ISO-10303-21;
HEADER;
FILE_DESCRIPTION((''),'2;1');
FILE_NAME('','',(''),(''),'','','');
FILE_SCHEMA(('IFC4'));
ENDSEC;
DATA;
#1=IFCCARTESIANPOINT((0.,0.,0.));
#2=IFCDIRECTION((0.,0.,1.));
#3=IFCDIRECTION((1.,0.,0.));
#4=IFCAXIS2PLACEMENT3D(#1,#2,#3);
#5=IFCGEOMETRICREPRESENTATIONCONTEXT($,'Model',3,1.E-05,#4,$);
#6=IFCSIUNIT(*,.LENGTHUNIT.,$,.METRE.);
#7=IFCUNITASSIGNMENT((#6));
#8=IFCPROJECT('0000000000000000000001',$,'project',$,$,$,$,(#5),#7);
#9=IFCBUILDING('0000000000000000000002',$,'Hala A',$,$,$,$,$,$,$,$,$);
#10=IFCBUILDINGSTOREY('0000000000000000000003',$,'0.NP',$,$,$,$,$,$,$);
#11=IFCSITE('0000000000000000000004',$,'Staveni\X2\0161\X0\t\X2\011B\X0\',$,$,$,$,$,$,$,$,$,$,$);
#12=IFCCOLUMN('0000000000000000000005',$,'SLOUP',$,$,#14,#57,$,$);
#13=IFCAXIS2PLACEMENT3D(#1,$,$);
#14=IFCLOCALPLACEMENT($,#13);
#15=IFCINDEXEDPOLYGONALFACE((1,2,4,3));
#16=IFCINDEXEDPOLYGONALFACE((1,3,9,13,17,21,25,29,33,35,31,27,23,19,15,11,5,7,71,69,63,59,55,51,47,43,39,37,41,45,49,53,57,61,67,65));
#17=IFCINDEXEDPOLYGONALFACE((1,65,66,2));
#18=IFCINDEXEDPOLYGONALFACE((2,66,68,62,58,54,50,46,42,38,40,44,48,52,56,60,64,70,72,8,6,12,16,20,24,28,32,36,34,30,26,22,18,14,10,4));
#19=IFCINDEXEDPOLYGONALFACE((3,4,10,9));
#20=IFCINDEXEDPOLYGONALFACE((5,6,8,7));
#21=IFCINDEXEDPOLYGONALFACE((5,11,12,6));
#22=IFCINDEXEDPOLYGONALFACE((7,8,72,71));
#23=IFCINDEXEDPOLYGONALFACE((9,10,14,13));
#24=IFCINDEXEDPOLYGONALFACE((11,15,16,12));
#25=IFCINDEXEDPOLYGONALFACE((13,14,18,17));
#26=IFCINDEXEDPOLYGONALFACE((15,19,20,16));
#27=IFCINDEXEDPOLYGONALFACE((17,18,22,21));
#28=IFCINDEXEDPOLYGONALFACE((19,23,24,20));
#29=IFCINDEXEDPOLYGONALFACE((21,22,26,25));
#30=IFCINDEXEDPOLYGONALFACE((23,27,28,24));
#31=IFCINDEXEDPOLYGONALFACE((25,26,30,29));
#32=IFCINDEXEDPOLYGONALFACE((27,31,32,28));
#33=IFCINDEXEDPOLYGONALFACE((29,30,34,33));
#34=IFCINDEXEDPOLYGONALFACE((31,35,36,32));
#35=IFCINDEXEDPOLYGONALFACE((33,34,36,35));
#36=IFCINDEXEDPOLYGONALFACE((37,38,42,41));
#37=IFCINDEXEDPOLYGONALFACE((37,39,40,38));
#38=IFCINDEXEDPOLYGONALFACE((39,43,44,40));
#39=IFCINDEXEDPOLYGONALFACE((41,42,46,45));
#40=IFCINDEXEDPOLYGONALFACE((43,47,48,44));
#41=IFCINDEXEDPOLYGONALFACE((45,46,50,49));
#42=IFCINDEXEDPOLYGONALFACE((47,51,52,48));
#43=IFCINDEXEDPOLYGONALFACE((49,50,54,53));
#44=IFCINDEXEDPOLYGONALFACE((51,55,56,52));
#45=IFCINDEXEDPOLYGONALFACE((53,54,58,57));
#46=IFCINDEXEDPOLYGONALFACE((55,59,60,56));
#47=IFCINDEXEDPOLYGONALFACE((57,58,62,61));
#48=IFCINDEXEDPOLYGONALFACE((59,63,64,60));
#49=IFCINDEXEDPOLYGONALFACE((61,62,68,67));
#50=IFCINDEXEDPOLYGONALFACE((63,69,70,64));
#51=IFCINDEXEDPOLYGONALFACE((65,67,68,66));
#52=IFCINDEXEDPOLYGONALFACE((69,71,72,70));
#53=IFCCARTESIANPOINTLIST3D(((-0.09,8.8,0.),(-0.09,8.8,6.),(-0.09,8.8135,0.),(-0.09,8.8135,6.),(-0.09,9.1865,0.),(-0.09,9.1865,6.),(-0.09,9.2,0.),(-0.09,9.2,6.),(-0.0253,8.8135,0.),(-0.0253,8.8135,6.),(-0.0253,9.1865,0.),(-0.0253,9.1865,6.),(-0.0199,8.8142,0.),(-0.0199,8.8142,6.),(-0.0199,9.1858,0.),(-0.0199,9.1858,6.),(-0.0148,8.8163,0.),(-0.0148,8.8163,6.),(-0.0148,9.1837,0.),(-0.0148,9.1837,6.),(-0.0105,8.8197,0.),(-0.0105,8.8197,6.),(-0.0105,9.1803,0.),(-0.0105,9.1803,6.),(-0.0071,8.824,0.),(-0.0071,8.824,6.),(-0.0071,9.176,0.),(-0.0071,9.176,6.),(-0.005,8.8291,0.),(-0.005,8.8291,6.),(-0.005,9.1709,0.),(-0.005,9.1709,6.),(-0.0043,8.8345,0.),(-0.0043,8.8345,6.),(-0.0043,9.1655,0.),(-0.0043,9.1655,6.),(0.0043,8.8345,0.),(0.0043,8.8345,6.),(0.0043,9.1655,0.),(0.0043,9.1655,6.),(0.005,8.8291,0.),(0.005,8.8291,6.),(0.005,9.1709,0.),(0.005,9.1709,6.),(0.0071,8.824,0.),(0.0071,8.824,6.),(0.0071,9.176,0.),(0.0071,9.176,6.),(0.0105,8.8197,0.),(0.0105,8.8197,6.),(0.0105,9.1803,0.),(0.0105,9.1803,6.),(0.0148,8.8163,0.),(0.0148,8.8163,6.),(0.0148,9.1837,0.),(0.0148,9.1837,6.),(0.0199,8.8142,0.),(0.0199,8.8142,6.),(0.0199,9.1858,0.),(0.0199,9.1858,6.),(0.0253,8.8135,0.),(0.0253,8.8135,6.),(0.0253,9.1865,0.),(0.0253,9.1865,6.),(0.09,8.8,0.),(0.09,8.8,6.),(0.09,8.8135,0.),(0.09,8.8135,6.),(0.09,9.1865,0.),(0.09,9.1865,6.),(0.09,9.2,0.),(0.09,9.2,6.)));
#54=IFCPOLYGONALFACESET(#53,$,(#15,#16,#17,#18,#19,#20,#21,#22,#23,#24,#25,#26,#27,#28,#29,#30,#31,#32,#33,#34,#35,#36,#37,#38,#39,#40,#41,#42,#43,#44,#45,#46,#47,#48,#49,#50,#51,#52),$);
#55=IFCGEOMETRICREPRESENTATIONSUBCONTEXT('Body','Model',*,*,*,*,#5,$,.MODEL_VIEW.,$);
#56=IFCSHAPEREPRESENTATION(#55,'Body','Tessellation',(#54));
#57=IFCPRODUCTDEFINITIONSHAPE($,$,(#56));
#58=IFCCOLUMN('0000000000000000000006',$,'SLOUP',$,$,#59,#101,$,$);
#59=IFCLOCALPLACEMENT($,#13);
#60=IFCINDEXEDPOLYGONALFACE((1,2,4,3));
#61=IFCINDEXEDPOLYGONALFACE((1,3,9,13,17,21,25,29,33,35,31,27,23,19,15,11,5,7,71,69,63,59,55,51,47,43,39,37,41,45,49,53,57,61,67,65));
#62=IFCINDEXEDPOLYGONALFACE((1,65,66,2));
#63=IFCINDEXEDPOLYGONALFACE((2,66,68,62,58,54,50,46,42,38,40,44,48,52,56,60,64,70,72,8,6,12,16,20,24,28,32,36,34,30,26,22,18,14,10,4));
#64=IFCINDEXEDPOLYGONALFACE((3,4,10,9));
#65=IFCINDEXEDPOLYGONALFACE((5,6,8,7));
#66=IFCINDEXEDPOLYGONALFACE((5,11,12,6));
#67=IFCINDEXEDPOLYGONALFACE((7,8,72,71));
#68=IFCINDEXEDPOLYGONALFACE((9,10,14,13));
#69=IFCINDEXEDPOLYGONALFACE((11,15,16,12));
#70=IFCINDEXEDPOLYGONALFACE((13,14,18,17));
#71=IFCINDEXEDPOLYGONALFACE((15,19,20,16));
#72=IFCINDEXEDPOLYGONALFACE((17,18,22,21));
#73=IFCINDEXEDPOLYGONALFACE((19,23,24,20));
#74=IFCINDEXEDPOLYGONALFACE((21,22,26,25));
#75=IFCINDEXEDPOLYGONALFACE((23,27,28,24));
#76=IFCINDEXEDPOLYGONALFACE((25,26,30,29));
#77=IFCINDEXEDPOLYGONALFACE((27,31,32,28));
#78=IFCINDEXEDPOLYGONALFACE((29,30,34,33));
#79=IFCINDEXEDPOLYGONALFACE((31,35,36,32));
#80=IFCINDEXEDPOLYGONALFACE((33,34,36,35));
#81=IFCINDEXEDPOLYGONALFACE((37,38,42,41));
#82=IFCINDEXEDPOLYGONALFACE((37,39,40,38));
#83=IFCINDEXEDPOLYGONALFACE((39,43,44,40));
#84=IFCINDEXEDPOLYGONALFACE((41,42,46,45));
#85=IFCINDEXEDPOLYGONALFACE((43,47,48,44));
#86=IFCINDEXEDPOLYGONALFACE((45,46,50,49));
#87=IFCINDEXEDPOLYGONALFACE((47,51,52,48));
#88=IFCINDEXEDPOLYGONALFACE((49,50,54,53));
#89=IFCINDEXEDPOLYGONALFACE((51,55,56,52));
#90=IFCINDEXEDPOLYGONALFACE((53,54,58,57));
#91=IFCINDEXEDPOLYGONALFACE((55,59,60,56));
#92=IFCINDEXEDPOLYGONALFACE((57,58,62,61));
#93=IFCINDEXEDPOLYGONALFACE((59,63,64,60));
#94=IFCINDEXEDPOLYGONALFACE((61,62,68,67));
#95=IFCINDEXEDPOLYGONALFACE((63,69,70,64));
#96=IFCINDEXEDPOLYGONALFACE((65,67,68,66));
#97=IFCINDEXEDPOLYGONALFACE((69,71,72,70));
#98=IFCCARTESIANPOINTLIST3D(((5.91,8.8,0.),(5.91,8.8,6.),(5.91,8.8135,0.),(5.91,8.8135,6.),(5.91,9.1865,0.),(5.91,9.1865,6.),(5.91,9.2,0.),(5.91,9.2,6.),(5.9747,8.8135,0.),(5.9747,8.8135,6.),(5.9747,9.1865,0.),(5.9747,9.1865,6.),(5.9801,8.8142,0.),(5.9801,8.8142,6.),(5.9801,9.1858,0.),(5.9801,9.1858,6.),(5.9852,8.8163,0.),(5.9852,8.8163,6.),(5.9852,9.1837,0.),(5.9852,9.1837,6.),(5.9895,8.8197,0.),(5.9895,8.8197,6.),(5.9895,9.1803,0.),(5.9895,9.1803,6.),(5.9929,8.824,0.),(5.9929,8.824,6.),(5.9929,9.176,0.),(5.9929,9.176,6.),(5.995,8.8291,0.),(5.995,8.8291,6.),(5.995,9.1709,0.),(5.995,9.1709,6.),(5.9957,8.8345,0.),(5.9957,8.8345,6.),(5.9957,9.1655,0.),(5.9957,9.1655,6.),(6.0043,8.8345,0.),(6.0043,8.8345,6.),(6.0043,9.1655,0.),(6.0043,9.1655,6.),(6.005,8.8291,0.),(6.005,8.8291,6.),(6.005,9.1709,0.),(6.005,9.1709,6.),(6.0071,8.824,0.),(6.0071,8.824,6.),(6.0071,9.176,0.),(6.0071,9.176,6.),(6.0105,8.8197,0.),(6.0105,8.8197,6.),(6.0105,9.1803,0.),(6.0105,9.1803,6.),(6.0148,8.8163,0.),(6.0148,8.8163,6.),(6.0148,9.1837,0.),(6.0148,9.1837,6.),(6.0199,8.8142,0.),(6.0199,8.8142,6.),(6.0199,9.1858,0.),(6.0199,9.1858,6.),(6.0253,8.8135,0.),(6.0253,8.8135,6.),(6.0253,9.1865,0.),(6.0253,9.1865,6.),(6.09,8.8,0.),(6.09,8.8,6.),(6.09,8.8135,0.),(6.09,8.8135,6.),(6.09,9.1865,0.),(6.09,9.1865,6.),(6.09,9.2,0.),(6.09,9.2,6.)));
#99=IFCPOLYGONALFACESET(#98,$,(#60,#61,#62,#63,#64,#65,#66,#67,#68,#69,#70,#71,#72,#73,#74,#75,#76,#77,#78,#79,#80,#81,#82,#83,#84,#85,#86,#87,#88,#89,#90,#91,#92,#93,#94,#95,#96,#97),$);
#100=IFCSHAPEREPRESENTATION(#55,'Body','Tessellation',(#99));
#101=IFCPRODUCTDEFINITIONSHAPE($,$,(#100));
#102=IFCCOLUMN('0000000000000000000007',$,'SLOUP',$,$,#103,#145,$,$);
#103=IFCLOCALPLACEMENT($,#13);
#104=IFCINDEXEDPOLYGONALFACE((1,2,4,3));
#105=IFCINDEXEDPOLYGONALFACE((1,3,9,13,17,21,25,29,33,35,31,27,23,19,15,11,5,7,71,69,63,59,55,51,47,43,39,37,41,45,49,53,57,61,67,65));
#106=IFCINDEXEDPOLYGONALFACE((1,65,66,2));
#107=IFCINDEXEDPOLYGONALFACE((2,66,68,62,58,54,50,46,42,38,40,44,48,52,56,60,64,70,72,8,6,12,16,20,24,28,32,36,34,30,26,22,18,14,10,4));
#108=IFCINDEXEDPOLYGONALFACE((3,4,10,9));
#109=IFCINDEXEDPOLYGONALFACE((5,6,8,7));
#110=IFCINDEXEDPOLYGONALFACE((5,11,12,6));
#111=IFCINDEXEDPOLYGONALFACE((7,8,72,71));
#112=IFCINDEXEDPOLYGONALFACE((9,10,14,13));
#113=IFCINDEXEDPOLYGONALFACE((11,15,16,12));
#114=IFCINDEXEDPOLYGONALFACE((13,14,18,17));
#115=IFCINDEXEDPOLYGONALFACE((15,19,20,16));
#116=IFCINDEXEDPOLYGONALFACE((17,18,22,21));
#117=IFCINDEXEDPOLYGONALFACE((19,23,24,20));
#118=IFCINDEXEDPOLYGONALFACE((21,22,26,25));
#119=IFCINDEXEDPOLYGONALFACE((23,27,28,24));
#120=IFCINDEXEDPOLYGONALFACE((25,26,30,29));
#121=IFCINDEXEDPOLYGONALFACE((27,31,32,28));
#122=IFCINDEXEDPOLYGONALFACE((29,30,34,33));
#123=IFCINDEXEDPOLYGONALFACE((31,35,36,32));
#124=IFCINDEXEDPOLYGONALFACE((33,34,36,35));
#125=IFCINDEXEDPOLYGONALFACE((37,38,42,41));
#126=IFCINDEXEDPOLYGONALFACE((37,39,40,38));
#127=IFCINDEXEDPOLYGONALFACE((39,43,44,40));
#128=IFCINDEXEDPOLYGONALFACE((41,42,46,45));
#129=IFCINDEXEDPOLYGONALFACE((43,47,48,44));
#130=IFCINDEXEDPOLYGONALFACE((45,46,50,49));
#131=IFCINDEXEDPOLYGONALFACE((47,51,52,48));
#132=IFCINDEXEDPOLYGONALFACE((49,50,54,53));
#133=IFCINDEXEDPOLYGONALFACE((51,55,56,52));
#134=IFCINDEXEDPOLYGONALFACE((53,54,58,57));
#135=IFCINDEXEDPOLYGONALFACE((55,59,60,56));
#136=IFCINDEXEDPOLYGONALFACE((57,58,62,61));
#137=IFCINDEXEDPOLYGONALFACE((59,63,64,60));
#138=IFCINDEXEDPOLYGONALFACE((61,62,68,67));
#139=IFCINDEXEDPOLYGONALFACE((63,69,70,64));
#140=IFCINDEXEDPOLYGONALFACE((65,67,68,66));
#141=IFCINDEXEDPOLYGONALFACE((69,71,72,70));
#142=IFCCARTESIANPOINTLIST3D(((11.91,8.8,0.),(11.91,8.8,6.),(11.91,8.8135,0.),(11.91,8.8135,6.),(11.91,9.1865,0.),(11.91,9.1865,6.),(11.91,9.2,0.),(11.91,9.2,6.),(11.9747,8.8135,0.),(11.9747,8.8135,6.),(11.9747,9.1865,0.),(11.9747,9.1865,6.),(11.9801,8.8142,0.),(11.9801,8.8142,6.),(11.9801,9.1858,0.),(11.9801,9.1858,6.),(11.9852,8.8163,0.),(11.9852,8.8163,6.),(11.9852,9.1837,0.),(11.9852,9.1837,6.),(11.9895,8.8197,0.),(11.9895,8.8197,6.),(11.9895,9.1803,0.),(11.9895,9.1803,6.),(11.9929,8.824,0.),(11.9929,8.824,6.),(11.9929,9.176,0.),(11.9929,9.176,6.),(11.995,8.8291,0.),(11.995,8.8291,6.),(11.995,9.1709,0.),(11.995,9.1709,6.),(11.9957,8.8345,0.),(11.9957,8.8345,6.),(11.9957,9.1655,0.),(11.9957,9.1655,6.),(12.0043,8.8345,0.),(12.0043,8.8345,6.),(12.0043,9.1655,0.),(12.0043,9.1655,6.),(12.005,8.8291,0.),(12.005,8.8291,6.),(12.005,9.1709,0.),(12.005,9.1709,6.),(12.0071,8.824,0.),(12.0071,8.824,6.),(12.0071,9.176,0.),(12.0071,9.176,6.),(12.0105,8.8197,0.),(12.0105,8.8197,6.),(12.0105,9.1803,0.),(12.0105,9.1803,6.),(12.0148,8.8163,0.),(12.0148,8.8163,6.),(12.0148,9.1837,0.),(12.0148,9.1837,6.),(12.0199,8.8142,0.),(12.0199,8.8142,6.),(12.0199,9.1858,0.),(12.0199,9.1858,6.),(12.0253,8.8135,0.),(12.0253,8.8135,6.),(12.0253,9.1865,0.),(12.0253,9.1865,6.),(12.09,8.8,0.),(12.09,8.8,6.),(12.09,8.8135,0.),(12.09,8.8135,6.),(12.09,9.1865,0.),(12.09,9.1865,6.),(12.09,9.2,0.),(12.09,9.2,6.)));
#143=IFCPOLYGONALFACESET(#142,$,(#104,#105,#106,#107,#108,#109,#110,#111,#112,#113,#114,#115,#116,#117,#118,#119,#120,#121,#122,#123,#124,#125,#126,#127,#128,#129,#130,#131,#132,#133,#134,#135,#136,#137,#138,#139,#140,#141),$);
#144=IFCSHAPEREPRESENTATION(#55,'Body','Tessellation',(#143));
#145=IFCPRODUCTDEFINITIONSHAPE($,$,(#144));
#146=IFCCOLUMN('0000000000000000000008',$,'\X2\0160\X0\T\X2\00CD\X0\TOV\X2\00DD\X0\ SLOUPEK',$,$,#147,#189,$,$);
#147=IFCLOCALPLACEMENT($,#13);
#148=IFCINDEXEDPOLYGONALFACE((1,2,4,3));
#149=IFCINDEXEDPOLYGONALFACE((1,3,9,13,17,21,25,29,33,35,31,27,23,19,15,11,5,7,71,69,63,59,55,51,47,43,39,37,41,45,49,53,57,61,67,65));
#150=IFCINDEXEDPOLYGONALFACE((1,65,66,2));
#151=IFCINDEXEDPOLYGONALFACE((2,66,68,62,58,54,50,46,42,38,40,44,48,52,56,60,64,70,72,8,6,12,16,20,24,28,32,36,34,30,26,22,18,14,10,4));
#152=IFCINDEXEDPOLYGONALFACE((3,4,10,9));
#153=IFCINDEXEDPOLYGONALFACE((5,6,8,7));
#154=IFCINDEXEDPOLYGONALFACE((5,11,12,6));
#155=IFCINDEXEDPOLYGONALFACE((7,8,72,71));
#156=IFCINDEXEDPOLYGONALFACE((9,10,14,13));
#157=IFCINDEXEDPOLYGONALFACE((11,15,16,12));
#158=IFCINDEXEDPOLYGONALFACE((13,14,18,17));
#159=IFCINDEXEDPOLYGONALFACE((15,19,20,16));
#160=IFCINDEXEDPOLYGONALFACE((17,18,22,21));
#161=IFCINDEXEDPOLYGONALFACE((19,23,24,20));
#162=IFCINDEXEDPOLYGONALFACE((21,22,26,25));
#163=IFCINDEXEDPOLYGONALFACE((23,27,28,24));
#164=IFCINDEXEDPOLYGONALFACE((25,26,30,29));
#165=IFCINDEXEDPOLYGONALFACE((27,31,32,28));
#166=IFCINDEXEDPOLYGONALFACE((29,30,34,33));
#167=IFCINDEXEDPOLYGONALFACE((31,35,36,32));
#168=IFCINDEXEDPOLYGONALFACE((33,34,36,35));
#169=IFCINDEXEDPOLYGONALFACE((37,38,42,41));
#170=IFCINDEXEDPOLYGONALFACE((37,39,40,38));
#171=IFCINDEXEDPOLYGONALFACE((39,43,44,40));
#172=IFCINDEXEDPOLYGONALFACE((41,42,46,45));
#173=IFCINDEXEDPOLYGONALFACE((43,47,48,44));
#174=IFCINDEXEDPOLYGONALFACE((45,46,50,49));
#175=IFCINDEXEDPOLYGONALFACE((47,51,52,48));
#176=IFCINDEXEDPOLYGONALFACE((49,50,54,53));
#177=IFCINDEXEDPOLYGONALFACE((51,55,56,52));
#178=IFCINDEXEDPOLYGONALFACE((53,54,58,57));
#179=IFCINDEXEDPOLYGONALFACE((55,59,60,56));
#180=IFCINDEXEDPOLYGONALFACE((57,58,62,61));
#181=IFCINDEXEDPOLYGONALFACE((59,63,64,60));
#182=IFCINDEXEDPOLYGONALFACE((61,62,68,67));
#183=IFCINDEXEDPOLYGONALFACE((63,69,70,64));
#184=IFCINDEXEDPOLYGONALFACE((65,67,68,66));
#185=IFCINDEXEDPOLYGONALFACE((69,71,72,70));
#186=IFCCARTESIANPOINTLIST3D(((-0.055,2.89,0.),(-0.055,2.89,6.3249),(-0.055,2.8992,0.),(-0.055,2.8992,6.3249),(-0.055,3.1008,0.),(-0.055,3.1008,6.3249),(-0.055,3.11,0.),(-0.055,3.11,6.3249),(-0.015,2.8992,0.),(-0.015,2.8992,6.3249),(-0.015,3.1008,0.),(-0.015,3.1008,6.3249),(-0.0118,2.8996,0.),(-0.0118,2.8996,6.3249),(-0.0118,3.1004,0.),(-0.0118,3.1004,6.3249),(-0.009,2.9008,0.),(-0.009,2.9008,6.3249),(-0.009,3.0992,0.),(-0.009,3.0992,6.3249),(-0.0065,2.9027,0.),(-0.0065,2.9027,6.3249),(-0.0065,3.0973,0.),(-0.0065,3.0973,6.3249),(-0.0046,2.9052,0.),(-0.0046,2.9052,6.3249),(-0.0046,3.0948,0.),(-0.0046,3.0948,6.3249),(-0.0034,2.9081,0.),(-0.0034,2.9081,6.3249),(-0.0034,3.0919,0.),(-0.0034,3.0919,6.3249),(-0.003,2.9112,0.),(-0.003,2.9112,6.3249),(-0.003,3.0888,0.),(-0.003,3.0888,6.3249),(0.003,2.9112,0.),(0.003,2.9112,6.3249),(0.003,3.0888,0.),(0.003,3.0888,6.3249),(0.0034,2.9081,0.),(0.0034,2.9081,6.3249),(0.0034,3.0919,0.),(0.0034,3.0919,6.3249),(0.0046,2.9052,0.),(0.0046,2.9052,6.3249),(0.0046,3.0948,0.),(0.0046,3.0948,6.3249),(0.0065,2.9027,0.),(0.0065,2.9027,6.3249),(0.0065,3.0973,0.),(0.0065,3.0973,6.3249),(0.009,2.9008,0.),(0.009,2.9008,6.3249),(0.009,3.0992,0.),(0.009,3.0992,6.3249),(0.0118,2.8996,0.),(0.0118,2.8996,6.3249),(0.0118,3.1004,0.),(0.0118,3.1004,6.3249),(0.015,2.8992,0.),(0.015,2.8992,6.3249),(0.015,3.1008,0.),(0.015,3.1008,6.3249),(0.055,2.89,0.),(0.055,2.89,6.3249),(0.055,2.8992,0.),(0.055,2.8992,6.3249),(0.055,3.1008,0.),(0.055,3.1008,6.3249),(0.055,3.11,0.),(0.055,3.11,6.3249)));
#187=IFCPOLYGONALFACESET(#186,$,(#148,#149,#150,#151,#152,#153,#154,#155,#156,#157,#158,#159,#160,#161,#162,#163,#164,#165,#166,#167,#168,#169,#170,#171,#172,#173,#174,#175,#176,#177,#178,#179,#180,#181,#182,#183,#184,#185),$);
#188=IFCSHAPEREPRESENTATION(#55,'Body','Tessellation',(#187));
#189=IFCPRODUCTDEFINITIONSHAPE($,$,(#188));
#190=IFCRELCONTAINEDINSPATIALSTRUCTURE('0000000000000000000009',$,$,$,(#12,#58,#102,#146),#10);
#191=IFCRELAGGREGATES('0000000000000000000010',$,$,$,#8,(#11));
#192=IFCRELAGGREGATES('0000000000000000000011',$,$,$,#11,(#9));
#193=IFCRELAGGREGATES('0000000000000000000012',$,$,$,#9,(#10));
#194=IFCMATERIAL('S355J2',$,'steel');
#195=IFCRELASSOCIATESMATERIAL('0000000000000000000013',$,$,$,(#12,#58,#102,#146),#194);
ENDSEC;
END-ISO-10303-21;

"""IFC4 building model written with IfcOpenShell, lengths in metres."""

from ifc_helpers import new_model, si_unit, frame, origin_with_axes, place, context, subcontext, project, spatial, i_section, extrude, material, element, save


model = new_model("IFC4")

# Units and contexts
model_context = context("Model", 3, precision=1e-05, world=origin_with_axes())
body_context = subcontext(model_context, "Body", "Model", "MODEL_VIEW")
ifc_project = project(units=[si_unit("LENGTHUNIT", "METRE")], contexts=[model_context])

# Site, building, storey
site = spatial("IfcSite", under=ifc_project, Name="Staveniště")
building = spatial("IfcBuilding", under=site, Name="Hala A")
storey = spatial("IfcBuildingStorey", under=building, Name="0.NP")

# Columns
ifc_material = material(Name="S355J2", Category="steel")
for number, where, z_axis, x_axis, name in (
    (1, (0.0, 9.0, 0.0), (0.0, 0.0, 1.0), (1.0, 0.0, 0.0), "SLOUP"),
    (2, (6.0, 9.0, 0.0), (0.0, 0.0, 1.0), (1.0, 0.0, 0.0), "SLOUP"),
    (3, (12.0, 9.0, 0.0), (0.0, 0.0, 1.0), (1.0, 0.0, 0.0), "SLOUP"),
):
    element("IfcColumn", number, at=place(None, frame(where, z_axis=z_axis, x_axis=x_axis)), inside=storey, material=ifc_material, Name=name, context=body_context, shape_type="SweptSolid", body=[
        extrude(i_section(OverallWidth=0.18, OverallDepth=0.4, WebThickness=0.0086, FlangeThickness=0.0135, FilletRadius=0.021), origin_with_axes(), (0.0, 0.0, 1.0), 6.0),
    ])
column_placement = place(None, frame((0.0, 3.0, 0.0), z_axis=(0.0, 0.0, 1.0), x_axis=(1.0, 0.0, 0.0)))
element("IfcColumn", 4, at=column_placement, inside=storey, material=ifc_material, Name="ŠTÍTOVÝ SLOUPEK", context=body_context, shape_type="SweptSolid", body=[
    extrude(i_section(OverallWidth=0.11, OverallDepth=0.22, WebThickness=0.0059, FlangeThickness=0.0092, FilletRadius=0.012), origin_with_axes(), (0.0, 0.0, 1.0), 6.3249),
])

save(model, "model.ifc")
